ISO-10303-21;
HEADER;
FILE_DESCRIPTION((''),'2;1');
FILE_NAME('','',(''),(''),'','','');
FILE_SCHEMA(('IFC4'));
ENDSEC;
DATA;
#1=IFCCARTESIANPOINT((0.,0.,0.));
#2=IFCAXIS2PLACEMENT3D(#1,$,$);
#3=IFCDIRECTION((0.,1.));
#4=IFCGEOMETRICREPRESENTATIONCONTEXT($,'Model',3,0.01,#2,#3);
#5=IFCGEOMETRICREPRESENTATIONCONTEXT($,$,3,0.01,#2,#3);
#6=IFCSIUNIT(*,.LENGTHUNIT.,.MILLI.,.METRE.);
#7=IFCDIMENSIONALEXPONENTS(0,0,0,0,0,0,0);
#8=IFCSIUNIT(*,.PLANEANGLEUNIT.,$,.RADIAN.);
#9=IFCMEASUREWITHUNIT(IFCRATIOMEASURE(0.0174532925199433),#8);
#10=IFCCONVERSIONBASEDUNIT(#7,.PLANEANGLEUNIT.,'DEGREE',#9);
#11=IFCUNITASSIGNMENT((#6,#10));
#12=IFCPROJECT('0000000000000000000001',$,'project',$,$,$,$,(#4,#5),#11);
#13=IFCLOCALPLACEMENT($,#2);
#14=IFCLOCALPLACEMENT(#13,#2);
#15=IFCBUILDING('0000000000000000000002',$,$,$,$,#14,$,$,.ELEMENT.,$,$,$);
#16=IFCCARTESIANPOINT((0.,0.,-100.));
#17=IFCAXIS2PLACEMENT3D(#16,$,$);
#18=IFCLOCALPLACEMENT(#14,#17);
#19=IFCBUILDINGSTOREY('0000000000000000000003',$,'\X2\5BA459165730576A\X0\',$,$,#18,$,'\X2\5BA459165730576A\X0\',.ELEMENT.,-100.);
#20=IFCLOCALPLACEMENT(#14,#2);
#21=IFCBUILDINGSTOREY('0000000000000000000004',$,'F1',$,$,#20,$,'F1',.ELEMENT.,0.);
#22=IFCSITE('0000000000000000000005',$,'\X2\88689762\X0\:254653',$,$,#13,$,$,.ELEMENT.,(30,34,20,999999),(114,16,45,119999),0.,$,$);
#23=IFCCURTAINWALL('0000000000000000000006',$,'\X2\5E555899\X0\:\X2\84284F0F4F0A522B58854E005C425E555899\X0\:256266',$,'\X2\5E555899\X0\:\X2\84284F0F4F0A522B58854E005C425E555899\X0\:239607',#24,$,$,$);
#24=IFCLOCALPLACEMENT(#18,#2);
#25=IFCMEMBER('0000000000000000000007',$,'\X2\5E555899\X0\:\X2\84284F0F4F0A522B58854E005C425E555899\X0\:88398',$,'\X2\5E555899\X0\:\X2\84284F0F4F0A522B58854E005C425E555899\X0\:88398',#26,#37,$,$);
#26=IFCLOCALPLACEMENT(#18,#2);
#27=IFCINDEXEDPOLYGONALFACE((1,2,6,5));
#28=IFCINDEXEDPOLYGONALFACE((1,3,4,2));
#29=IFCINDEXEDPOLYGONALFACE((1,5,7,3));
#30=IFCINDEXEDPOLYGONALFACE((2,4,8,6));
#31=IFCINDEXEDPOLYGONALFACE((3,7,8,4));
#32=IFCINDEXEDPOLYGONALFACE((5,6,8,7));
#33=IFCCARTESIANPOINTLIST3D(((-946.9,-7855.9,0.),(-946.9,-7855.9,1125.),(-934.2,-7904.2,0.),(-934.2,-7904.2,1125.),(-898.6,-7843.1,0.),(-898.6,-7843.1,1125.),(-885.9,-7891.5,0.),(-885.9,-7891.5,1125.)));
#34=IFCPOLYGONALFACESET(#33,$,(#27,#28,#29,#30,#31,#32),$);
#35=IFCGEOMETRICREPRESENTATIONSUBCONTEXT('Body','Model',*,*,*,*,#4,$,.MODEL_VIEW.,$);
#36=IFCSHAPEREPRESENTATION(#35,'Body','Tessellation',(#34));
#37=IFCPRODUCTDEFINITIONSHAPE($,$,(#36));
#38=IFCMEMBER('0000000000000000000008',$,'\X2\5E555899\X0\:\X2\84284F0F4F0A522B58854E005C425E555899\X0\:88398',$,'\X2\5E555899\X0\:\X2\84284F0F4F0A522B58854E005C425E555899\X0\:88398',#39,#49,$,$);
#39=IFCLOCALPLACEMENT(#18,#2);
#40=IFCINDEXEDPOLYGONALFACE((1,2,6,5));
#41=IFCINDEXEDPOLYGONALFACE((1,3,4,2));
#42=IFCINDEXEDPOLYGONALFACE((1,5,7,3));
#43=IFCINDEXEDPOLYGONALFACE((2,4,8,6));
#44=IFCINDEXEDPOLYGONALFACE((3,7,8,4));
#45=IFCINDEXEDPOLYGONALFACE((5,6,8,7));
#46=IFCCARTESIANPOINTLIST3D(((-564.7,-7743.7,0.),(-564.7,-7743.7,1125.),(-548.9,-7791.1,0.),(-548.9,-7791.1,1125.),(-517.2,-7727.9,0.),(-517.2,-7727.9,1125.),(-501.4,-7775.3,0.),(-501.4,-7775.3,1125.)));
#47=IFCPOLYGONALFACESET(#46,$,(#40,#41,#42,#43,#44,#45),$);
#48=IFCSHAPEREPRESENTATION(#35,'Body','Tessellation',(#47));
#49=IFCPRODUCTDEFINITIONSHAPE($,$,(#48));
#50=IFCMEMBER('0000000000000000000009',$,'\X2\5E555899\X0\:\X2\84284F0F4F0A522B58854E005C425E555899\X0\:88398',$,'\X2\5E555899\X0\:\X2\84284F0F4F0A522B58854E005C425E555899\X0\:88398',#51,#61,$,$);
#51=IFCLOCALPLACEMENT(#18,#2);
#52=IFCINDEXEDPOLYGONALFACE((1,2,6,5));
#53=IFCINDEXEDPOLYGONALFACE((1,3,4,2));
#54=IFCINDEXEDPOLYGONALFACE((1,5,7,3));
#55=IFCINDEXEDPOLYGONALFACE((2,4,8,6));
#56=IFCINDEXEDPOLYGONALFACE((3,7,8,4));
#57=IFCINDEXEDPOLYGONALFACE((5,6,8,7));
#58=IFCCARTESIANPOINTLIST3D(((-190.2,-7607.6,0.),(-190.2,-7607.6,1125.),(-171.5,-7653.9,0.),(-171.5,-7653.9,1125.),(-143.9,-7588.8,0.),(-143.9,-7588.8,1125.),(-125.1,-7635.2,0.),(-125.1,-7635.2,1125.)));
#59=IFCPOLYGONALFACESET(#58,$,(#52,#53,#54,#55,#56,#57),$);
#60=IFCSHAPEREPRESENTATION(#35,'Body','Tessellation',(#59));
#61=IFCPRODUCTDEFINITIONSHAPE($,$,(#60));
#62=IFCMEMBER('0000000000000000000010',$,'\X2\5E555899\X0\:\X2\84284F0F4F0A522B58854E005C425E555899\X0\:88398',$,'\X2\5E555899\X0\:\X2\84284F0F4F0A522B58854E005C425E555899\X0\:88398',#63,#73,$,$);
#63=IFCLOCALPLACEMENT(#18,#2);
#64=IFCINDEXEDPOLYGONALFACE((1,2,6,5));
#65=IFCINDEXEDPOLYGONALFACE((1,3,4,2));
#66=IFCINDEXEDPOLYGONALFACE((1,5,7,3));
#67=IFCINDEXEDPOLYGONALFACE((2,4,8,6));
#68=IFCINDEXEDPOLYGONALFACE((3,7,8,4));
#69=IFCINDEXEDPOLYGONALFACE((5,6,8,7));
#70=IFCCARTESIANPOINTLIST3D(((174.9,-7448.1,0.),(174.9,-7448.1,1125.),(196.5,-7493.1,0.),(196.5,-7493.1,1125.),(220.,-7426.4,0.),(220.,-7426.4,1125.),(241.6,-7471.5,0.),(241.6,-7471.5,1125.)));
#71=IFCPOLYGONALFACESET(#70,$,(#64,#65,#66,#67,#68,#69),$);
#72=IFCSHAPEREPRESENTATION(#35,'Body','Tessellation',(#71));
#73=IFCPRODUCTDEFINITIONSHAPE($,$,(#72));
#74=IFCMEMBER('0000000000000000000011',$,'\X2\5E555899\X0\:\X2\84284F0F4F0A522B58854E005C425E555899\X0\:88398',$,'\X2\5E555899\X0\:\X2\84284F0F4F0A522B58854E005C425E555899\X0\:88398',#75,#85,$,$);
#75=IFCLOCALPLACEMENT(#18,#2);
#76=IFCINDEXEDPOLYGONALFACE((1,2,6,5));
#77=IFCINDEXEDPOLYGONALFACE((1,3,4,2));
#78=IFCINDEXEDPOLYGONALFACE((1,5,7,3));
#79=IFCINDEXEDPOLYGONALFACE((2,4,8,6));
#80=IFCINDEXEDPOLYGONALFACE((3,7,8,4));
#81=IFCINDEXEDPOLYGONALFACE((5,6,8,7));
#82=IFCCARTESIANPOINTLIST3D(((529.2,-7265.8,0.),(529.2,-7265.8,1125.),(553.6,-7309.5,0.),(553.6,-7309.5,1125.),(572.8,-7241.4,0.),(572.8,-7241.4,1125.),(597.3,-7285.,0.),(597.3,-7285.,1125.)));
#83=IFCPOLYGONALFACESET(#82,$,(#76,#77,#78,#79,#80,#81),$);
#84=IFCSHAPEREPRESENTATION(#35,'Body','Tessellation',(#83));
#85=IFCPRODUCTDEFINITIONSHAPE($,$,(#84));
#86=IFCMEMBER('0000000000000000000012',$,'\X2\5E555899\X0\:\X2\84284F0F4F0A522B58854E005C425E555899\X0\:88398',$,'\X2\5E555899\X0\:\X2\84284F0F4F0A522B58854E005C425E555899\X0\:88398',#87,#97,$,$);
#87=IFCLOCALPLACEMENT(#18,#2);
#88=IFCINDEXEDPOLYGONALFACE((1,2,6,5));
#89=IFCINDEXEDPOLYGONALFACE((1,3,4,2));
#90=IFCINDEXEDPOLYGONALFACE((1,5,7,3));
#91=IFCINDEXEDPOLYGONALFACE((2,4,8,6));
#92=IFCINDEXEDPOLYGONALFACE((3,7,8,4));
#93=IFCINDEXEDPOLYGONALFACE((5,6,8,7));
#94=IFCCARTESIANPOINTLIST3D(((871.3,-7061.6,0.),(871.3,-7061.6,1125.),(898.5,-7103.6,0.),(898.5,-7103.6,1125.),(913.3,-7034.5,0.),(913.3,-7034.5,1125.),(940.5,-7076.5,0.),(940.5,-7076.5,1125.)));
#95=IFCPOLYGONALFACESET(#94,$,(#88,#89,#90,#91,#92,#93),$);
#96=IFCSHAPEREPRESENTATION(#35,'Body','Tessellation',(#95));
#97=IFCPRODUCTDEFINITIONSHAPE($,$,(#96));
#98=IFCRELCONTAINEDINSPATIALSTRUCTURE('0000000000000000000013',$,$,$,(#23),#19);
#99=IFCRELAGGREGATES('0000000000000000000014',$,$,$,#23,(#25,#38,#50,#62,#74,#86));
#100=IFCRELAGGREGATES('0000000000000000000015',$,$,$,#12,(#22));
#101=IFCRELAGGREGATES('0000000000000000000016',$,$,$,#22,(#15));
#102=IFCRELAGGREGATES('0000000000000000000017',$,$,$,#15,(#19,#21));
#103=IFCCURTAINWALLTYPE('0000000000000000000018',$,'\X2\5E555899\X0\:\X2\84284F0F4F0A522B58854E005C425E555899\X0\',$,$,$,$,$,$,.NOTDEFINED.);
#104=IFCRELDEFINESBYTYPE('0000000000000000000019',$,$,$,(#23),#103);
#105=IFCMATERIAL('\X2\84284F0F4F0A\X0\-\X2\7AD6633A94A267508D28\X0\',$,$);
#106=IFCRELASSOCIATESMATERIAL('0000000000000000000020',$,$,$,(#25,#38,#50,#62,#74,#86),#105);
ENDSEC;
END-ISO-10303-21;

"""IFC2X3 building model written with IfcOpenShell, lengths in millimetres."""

from ifc_helpers import new_model, entity, si_unit, converted_unit, direction, frame, frame_2d, origin, origin_2d_with_axis, place, context, subcontext, project, spatial, rectangle, extrude, material, type_object, element, aggregate, save


model = new_model("IFC2X3")

# Units and contexts
model_context = context("Model", 3, precision=0.01, world=origin(), true_north=direction((0.0, 1.0)))
context_of_model = context(None, 3, precision=0.01, world=origin(), true_north=direction((0.0, 1.0)))
body_context = subcontext(model_context, "Body", "Model", "MODEL_VIEW")
ifc_project = project(units=[si_unit("LENGTHUNIT", "METRE", prefix="MILLI"), converted_unit("PLANEANGLEUNIT", "DEGREE", entity("IfcRatioMeasure", 0.0174532925199433), si_unit("PLANEANGLEUNIT", "RADIAN"), dimensions=[0, 0, 0, 0, 0, 0, 0])], contexts=[model_context, context_of_model])

# Site, building, storey
site_placement = place(None, origin())
site = spatial("IfcSite", under=ifc_project, at=site_placement, Name="表面:254653", CompositionType="ELEMENT", RefLatitude=(30, 34, 20, 999999), RefLongitude=(114, 16, 45, 119999), RefElevation=0.0)
building_placement = place(site_placement, origin())
building = spatial("IfcBuilding", under=site, at=building_placement, CompositionType="ELEMENT")
storey_1_placement = place(building_placement, frame((0.0, 0.0, -100.0)))
storey_1 = spatial("IfcBuildingStorey", under=building, at=storey_1_placement, Name="室外地坪", LongName="室外地坪", CompositionType="ELEMENT", Elevation=-100.0)

# Curtain wall, members
curtain_wall_type = type_object("IfcCurtainWallType", Name="幕墙:萨伏伊别墅一层幕墙", PredefinedType="NOTDEFINED")
curtain_wall_placement = place(storey_1_placement, frame((0.0, 0.0, 100.0)))
curtain_wall = element("IfcCurtainWall", 1, at=curtain_wall_placement, inside=storey_1, type_object=curtain_wall_type, Name="幕墙:萨伏伊别墅一层幕墙:256266", ObjectType="幕墙:萨伏伊别墅一层幕墙:239607")
ifc_material_1 = material(Name="萨伏伊-竖挺钢材质")
member_1_placement = place(curtain_wall_placement, origin())
member_1 = element("IfcMember", 2, at=member_1_placement, material=ifc_material_1, Name="幕墙:萨伏伊别墅一层幕墙:88398", ObjectType="幕墙:萨伏伊别墅一层幕墙:88398", context=body_context, shape_type="SweptSolid", body=[
    extrude(rectangle(XDim=50.0, YDim=50.0, at=origin_2d_with_axis()), frame((-916.4, -7873.7, -100.0), z_axis=(0.0, 0.0, 1.0), x_axis=(0.96693, 0.255043, 0.0)), (0.0, 0.0, 1.0), 1125.0),
])
member_2_placement = place(curtain_wall_placement, origin())
member_2 = element("IfcMember", 3, at=member_2_placement, material=ifc_material_1, Name="幕墙:萨伏伊别墅一层幕墙:88398", ObjectType="幕墙:萨伏伊别墅一层幕墙:88398", context=body_context, shape_type="SweptSolid", body=[
    extrude(rectangle(XDim=50.0, YDim=50.0, at=frame_2d((0.0, 0.0), x_axis=(1.0, 0.0))), frame((-533.0, -7759.5, -100.0), z_axis=(0.0, 0.0, 1.0), x_axis=(0.948901, 0.315573, 0.0)), (0.0, 0.0, 1.0), 1125.0),
])
member_3_placement = place(curtain_wall_placement, origin())
member_3 = element("IfcMember", 4, at=member_3_placement, material=ifc_material_1, Name="幕墙:萨伏伊别墅一层幕墙:88398", ObjectType="幕墙:萨伏伊别墅一层幕墙:88398", context=body_context, shape_type="SweptSolid", body=[
    extrude(rectangle(XDim=50.0, YDim=50.0, at=frame_2d((0.0, 0.0), x_axis=(1.0, 0.0))), frame((-157.7, -7621.4, -100.0), z_axis=(0.0, 0.0, 1.0), x_axis=(0.927088, 0.374844, 0.0)), (0.0, 0.0, 1.0), 1125.0),
])
member_4_placement = place(curtain_wall_placement, origin())
member_4 = element("IfcMember", 5, at=member_4_placement, material=ifc_material_1, Name="幕墙:萨伏伊别墅一层幕墙:88398", ObjectType="幕墙:萨伏伊别墅一层幕墙:88398", context=body_context, shape_type="SweptSolid", body=[
    extrude(rectangle(XDim=50.0, YDim=50.0, at=frame_2d((0.0, 0.0), x_axis=(1.0, 0.0))), frame((208.3, -7459.8, -100.0), z_axis=(0.0, 0.0, 1.0), x_axis=(0.901576, 0.43262, 0.0)), (0.0, 0.0, 1.0), 1125.0),
])
member_5_placement = place(curtain_wall_placement, origin())
member_5 = element("IfcMember", 6, at=member_5_placement, material=ifc_material_1, Name="幕墙:萨伏伊别墅一层幕墙:88398", ObjectType="幕墙:萨伏伊别墅一层幕墙:88398", context=body_context, shape_type="SweptSolid", body=[
    extrude(rectangle(XDim=50.0, YDim=50.0, at=origin_2d_with_axis()), frame((563.2, -7275.4, -100.0), z_axis=(0.0, 0.0, 1.0), x_axis=(0.872468, 0.488671, 0.0)), (0.0, 0.0, 1.0), 1125.0),
])
member_6_placement = place(curtain_wall_placement, origin())
member_6 = element("IfcMember", 7, at=member_6_placement, material=ifc_material_1, Name="幕墙:萨伏伊别墅一层幕墙:88398", ObjectType="幕墙:萨伏伊别墅一层幕墙:88398", context=body_context, shape_type="SweptSolid", body=[
    extrude(rectangle(XDim=50.0, YDim=50.0, at=frame_2d((0.0, 0.0), x_axis=(1.0, 0.0))), frame((905.9, -7069.0, -100.0), z_axis=(0.0, 0.0, 1.0), x_axis=(0.83988, 0.542772, 0.0)), (0.0, 0.0, 1.0), 1125.0),
])
aggregate(curtain_wall, [member_1, member_2, member_3, member_4, member_5, member_6])

# Shared definitions
storey_2_placement = place(building_placement, origin())
storey_2 = spatial("IfcBuildingStorey", under=building, at=storey_2_placement, Name="F1", LongName="F1", CompositionType="ELEMENT", Elevation=0.0)

save(model, "model.ifc")
